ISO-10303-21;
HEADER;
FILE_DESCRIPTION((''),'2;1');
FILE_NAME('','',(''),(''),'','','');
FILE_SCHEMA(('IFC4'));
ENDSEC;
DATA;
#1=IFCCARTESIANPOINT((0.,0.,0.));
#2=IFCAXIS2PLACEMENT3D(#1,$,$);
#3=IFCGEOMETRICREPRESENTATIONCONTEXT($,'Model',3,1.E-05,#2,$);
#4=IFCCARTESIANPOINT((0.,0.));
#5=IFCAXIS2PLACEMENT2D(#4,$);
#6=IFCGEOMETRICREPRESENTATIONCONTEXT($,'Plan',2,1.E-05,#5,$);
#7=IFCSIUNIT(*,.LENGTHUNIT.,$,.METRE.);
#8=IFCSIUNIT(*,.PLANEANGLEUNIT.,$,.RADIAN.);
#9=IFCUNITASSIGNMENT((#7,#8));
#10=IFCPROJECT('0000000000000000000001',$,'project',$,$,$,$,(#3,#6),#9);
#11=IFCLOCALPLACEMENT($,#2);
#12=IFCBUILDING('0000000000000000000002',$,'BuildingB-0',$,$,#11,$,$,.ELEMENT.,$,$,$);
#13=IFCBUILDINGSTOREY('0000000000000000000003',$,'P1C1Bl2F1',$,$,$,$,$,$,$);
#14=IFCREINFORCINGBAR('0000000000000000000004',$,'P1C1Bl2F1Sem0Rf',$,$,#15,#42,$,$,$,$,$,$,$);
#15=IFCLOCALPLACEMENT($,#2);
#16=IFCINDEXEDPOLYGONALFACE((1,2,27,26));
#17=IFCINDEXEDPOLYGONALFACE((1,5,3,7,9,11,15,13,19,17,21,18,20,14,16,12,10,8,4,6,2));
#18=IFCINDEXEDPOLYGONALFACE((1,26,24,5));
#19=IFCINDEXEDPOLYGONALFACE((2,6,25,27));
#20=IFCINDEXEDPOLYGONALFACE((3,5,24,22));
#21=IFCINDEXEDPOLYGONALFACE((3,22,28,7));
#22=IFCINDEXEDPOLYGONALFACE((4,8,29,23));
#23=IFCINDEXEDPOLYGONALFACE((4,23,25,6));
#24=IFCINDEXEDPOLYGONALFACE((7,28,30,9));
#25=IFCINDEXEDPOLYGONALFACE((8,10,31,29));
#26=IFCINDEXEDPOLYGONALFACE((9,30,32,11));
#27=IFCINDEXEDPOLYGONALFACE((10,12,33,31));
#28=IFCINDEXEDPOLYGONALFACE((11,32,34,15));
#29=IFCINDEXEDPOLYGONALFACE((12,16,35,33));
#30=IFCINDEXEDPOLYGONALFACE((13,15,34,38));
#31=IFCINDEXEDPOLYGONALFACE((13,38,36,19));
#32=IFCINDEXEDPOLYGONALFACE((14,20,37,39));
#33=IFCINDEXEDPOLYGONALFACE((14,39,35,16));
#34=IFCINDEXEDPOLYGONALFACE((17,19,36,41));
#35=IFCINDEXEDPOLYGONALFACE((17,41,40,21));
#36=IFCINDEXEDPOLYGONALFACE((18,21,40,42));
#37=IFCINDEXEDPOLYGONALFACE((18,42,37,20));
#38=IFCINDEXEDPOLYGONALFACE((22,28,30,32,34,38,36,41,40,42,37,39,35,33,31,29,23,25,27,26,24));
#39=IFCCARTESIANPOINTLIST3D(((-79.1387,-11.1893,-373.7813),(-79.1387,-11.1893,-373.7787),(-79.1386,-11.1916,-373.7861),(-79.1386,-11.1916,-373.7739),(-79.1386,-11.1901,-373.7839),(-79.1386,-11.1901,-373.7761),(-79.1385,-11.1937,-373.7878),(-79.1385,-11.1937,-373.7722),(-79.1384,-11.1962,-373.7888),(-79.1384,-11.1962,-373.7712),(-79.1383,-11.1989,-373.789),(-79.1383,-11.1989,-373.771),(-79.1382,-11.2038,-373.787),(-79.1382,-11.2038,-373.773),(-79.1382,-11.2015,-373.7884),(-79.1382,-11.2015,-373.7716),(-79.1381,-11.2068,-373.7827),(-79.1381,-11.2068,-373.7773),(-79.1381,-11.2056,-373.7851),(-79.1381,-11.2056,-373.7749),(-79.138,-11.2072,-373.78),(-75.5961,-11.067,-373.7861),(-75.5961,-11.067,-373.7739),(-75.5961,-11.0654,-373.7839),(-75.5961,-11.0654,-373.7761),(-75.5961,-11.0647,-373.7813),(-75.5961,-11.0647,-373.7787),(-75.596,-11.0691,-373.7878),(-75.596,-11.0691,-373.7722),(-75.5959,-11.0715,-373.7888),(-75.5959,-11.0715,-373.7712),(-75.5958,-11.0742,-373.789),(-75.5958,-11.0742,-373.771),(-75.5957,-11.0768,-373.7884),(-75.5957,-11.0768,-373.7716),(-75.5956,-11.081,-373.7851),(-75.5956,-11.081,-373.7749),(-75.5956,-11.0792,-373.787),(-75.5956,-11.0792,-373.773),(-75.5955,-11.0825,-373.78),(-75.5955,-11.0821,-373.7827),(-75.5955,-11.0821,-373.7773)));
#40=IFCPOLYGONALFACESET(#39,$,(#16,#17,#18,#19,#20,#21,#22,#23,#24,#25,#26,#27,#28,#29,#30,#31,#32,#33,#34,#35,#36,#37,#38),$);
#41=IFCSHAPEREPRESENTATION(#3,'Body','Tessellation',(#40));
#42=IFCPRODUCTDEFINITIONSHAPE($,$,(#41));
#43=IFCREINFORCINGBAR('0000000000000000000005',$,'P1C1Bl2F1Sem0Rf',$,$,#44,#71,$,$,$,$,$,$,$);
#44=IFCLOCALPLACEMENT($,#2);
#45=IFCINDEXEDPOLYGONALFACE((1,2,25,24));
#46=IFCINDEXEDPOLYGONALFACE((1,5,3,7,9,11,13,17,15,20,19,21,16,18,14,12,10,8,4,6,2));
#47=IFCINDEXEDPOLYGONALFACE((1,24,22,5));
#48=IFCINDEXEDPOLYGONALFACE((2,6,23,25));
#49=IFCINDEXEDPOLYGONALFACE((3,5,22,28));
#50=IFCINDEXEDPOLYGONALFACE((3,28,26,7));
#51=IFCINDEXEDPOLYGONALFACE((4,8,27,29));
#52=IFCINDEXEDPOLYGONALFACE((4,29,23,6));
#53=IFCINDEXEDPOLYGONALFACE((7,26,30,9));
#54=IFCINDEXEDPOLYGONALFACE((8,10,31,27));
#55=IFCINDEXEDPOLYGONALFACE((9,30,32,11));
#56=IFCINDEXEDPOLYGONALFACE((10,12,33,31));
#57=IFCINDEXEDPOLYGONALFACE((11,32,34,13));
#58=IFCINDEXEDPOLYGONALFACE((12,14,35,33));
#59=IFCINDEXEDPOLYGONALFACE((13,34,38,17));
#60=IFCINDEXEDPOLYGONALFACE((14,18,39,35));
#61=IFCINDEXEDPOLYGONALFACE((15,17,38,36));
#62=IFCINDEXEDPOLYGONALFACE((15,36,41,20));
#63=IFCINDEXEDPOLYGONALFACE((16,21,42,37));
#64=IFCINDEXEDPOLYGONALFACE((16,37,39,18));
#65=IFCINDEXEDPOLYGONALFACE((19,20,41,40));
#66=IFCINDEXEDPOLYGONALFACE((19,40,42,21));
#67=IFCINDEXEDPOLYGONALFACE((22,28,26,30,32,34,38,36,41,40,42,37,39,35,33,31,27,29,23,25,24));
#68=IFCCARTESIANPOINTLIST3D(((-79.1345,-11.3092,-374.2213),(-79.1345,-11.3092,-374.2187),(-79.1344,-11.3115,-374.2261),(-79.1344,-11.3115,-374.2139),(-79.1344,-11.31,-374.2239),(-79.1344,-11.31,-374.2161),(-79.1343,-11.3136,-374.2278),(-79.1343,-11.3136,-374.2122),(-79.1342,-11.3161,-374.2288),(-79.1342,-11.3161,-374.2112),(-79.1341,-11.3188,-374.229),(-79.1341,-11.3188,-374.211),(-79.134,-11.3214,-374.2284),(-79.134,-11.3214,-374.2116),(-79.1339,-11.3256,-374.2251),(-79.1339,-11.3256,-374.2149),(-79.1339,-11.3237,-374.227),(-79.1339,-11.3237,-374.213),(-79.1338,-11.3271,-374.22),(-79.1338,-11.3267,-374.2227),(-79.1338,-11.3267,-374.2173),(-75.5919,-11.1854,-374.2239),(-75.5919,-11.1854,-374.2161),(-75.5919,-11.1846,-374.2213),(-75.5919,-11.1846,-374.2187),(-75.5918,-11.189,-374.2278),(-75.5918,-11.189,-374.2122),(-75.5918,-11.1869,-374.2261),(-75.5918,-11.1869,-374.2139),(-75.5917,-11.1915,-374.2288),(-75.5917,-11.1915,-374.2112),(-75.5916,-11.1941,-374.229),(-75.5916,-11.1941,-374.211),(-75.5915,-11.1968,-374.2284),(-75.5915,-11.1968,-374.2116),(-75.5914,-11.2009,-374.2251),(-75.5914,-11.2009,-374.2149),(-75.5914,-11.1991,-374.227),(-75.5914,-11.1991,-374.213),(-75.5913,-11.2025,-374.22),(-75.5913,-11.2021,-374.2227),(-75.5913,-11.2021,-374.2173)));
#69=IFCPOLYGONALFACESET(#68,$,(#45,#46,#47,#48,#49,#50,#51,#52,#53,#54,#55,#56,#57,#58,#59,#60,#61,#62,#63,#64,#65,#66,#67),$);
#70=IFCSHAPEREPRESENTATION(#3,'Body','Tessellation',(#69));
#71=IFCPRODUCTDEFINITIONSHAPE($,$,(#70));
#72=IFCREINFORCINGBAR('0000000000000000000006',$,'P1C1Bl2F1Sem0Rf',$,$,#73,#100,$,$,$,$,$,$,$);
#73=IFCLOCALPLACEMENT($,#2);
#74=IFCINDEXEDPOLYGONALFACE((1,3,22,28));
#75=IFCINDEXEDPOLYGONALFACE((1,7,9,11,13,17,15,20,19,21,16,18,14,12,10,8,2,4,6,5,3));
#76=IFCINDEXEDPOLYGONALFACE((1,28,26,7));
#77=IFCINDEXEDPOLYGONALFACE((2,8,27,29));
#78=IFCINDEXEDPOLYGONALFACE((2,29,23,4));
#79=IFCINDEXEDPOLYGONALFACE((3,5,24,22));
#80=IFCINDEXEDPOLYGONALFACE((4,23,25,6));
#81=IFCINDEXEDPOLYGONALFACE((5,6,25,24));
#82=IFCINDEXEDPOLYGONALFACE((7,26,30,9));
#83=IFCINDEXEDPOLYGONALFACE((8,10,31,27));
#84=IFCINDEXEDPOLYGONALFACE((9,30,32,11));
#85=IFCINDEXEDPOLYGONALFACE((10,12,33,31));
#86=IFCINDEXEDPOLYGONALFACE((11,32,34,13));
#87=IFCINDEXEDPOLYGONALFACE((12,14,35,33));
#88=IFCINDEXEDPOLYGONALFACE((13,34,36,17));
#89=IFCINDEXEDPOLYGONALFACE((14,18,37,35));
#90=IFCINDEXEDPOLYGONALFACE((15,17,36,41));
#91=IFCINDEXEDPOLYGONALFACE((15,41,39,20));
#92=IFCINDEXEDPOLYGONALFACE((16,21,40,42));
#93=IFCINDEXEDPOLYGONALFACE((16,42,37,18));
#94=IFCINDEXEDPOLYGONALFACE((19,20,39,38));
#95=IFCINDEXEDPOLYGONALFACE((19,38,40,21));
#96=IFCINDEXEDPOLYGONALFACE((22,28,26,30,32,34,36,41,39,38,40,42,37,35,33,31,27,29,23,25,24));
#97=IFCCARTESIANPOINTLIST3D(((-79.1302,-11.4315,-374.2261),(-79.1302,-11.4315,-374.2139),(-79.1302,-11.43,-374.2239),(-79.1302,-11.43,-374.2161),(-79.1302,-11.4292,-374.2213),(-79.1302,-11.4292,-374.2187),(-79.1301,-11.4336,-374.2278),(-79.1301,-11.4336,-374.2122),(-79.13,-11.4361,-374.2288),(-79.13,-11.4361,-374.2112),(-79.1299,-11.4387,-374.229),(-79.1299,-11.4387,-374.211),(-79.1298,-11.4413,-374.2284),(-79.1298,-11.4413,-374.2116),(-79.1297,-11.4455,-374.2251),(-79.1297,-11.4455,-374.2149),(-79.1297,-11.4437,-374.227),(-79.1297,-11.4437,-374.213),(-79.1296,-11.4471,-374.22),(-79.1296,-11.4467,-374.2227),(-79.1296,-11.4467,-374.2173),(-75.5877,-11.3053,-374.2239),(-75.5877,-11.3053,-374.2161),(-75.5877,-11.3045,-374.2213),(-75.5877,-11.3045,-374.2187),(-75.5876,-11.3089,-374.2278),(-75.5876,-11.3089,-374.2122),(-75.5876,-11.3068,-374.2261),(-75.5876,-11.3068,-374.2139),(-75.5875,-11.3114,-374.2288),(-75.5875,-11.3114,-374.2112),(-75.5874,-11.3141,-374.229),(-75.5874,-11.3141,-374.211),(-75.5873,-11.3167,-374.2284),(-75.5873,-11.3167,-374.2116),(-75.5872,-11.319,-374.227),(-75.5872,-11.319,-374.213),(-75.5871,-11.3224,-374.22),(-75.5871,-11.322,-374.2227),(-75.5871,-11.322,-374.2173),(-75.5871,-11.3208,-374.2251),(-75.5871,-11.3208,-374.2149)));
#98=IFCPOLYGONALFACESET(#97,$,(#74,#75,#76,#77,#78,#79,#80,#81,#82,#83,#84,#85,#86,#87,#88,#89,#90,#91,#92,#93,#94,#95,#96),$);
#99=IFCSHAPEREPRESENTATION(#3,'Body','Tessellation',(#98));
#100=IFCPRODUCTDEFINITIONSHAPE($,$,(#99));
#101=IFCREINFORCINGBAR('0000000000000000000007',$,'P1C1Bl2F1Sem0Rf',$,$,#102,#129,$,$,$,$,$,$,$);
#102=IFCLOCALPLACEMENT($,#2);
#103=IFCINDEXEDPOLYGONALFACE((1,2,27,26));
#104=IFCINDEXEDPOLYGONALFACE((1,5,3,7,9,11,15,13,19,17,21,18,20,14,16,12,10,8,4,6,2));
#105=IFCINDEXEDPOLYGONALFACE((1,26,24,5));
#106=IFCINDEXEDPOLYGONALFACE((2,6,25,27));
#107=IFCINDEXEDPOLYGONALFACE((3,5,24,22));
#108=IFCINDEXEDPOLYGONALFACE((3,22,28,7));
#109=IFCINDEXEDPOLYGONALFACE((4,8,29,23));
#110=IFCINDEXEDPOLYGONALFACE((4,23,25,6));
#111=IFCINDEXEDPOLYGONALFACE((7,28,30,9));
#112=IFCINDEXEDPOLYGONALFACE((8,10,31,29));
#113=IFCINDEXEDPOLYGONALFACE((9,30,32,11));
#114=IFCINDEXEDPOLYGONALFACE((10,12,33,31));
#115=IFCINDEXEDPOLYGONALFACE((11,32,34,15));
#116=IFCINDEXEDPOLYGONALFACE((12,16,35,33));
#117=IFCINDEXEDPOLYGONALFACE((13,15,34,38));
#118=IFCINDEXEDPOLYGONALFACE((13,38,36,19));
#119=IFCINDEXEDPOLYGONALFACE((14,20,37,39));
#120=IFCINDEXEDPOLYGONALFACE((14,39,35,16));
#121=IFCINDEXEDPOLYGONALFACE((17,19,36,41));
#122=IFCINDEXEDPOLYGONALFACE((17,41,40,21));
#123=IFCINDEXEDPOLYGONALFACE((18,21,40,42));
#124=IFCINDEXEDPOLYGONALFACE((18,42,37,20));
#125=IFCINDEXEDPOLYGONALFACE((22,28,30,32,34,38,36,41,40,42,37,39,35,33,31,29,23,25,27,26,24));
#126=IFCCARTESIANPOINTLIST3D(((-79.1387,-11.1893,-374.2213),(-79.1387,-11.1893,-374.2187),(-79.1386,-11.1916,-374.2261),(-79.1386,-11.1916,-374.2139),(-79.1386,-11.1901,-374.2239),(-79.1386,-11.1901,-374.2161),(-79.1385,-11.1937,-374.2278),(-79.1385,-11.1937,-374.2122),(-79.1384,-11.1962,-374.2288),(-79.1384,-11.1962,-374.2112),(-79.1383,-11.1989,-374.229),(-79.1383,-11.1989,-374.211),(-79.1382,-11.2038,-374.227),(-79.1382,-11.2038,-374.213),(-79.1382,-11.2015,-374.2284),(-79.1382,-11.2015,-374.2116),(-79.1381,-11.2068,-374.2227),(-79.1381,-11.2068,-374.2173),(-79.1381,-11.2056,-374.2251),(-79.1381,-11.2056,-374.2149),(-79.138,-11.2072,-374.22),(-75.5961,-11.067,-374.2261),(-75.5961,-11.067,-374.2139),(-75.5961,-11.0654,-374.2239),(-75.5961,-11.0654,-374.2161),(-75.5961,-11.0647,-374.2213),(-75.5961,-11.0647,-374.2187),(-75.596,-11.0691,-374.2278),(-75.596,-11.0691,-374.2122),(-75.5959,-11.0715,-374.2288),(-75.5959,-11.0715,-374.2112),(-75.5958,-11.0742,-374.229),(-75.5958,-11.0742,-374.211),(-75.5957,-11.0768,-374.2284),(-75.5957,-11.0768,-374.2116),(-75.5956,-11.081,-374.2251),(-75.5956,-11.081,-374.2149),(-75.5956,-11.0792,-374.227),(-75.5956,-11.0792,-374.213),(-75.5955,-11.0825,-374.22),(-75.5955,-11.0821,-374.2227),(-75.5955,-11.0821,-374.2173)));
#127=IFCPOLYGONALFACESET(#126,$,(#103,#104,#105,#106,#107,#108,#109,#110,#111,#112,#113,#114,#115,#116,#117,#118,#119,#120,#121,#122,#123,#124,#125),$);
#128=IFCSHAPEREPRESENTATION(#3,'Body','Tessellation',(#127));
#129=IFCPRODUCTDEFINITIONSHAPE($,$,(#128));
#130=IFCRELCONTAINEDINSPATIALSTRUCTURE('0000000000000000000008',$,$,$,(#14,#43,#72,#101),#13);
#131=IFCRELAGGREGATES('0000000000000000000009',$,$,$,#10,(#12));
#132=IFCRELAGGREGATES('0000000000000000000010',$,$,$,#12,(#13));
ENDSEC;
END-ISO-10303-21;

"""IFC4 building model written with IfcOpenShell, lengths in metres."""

from ifc_helpers import new_model, entity, si_unit, origin, origin_2d, place, context, project, spatial, element, save


model = new_model("IFC4")

# Units and contexts
model_context = context("Model", 3, precision=1e-05, world=origin())
plan_context = context("Plan", 2, precision=1e-05, world=origin_2d())
ifc_project = project(units=[si_unit("LENGTHUNIT", "METRE"), si_unit("PLANEANGLEUNIT", "RADIAN")], contexts=[model_context, plan_context])

# Building, storey
building_placement = place(None, origin())
building = spatial("IfcBuilding", under=ifc_project, at=building_placement, Name="BuildingB-0", CompositionType="ELEMENT")
storey = spatial("IfcBuildingStorey", under=building, Name="P1C1Bl2F1")

# Reinforcing bars
element("IfcReinforcingBar", 1, inside=storey, Name="P1C1Bl2F1Sem0Rf", context=model_context, shape_type="SweptSolid", body=[
    entity("IfcSurfaceCurveSweptAreaSolid", entity("IfcCircleProfileDef", "AREA", None, None, 0.009), None, entity("IfcPolyline", [entity("IfcCartesianPoint", [79.1384, 11.1982, 373.78]), entity("IfcCartesianPoint", [75.5958, 11.0735, 373.78])]), None, None, entity("IfcPlane", entity("IfcAxis2Placement3D", entity("IfcCartesianPoint", [79.1384, 11.1982, 373.78]), entity("IfcDirection", [0.0, 0.0, 1.0]), entity("IfcDirection", [1.0, 0.0, 0.0])))),
])
element("IfcReinforcingBar", 2, inside=storey, Name="P1C1Bl2F1Sem0Rf", context=model_context, shape_type="SweptSolid", body=[
    entity("IfcSurfaceCurveSweptAreaSolid", entity("IfcCircleProfileDef", "AREA", None, None, 0.009), None, entity("IfcPolyline", [entity("IfcCartesianPoint", [79.1341, 11.3181, 374.22]), entity("IfcCartesianPoint", [75.5916, 11.1935, 374.22])]), None, None, entity("IfcPlane", entity("IfcAxis2Placement3D", entity("IfcCartesianPoint", [79.1341, 11.3181, 374.22]), entity("IfcDirection", [0.0, 0.0, 1.0]), entity("IfcDirection", [1.0, 0.0, 0.0])))),
])
element("IfcReinforcingBar", 3, inside=storey, Name="P1C1Bl2F1Sem0Rf", context=model_context, shape_type="SweptSolid", body=[
    entity("IfcSurfaceCurveSweptAreaSolid", entity("IfcCircleProfileDef", "AREA", None, None, 0.009), None, entity("IfcPolyline", [entity("IfcCartesianPoint", [79.1299, 11.4381, 374.22]), entity("IfcCartesianPoint", [75.5874, 11.3134, 374.22])]), None, None, entity("IfcPlane", entity("IfcAxis2Placement3D", entity("IfcCartesianPoint", [79.1299, 11.4381, 374.22]), entity("IfcDirection", [0.0, 0.0, 1.0]), entity("IfcDirection", [1.0, 0.0, 0.0])))),
])
element("IfcReinforcingBar", 4, inside=storey, Name="P1C1Bl2F1Sem0Rf", context=model_context, shape_type="SweptSolid", body=[
    entity("IfcSurfaceCurveSweptAreaSolid", entity("IfcCircleProfileDef", "AREA", None, None, 0.009), None, entity("IfcPolyline", [entity("IfcCartesianPoint", [79.1384, 11.1982, 374.22]), entity("IfcCartesianPoint", [75.5958, 11.0735, 374.22])]), None, None, entity("IfcPlane", entity("IfcAxis2Placement3D", entity("IfcCartesianPoint", [79.1384, 11.1982, 374.22]), entity("IfcDirection", [0.0, 0.0, 1.0]), entity("IfcDirection", [1.0, 0.0, 0.0])))),
])

save(model, "model.ifc")
